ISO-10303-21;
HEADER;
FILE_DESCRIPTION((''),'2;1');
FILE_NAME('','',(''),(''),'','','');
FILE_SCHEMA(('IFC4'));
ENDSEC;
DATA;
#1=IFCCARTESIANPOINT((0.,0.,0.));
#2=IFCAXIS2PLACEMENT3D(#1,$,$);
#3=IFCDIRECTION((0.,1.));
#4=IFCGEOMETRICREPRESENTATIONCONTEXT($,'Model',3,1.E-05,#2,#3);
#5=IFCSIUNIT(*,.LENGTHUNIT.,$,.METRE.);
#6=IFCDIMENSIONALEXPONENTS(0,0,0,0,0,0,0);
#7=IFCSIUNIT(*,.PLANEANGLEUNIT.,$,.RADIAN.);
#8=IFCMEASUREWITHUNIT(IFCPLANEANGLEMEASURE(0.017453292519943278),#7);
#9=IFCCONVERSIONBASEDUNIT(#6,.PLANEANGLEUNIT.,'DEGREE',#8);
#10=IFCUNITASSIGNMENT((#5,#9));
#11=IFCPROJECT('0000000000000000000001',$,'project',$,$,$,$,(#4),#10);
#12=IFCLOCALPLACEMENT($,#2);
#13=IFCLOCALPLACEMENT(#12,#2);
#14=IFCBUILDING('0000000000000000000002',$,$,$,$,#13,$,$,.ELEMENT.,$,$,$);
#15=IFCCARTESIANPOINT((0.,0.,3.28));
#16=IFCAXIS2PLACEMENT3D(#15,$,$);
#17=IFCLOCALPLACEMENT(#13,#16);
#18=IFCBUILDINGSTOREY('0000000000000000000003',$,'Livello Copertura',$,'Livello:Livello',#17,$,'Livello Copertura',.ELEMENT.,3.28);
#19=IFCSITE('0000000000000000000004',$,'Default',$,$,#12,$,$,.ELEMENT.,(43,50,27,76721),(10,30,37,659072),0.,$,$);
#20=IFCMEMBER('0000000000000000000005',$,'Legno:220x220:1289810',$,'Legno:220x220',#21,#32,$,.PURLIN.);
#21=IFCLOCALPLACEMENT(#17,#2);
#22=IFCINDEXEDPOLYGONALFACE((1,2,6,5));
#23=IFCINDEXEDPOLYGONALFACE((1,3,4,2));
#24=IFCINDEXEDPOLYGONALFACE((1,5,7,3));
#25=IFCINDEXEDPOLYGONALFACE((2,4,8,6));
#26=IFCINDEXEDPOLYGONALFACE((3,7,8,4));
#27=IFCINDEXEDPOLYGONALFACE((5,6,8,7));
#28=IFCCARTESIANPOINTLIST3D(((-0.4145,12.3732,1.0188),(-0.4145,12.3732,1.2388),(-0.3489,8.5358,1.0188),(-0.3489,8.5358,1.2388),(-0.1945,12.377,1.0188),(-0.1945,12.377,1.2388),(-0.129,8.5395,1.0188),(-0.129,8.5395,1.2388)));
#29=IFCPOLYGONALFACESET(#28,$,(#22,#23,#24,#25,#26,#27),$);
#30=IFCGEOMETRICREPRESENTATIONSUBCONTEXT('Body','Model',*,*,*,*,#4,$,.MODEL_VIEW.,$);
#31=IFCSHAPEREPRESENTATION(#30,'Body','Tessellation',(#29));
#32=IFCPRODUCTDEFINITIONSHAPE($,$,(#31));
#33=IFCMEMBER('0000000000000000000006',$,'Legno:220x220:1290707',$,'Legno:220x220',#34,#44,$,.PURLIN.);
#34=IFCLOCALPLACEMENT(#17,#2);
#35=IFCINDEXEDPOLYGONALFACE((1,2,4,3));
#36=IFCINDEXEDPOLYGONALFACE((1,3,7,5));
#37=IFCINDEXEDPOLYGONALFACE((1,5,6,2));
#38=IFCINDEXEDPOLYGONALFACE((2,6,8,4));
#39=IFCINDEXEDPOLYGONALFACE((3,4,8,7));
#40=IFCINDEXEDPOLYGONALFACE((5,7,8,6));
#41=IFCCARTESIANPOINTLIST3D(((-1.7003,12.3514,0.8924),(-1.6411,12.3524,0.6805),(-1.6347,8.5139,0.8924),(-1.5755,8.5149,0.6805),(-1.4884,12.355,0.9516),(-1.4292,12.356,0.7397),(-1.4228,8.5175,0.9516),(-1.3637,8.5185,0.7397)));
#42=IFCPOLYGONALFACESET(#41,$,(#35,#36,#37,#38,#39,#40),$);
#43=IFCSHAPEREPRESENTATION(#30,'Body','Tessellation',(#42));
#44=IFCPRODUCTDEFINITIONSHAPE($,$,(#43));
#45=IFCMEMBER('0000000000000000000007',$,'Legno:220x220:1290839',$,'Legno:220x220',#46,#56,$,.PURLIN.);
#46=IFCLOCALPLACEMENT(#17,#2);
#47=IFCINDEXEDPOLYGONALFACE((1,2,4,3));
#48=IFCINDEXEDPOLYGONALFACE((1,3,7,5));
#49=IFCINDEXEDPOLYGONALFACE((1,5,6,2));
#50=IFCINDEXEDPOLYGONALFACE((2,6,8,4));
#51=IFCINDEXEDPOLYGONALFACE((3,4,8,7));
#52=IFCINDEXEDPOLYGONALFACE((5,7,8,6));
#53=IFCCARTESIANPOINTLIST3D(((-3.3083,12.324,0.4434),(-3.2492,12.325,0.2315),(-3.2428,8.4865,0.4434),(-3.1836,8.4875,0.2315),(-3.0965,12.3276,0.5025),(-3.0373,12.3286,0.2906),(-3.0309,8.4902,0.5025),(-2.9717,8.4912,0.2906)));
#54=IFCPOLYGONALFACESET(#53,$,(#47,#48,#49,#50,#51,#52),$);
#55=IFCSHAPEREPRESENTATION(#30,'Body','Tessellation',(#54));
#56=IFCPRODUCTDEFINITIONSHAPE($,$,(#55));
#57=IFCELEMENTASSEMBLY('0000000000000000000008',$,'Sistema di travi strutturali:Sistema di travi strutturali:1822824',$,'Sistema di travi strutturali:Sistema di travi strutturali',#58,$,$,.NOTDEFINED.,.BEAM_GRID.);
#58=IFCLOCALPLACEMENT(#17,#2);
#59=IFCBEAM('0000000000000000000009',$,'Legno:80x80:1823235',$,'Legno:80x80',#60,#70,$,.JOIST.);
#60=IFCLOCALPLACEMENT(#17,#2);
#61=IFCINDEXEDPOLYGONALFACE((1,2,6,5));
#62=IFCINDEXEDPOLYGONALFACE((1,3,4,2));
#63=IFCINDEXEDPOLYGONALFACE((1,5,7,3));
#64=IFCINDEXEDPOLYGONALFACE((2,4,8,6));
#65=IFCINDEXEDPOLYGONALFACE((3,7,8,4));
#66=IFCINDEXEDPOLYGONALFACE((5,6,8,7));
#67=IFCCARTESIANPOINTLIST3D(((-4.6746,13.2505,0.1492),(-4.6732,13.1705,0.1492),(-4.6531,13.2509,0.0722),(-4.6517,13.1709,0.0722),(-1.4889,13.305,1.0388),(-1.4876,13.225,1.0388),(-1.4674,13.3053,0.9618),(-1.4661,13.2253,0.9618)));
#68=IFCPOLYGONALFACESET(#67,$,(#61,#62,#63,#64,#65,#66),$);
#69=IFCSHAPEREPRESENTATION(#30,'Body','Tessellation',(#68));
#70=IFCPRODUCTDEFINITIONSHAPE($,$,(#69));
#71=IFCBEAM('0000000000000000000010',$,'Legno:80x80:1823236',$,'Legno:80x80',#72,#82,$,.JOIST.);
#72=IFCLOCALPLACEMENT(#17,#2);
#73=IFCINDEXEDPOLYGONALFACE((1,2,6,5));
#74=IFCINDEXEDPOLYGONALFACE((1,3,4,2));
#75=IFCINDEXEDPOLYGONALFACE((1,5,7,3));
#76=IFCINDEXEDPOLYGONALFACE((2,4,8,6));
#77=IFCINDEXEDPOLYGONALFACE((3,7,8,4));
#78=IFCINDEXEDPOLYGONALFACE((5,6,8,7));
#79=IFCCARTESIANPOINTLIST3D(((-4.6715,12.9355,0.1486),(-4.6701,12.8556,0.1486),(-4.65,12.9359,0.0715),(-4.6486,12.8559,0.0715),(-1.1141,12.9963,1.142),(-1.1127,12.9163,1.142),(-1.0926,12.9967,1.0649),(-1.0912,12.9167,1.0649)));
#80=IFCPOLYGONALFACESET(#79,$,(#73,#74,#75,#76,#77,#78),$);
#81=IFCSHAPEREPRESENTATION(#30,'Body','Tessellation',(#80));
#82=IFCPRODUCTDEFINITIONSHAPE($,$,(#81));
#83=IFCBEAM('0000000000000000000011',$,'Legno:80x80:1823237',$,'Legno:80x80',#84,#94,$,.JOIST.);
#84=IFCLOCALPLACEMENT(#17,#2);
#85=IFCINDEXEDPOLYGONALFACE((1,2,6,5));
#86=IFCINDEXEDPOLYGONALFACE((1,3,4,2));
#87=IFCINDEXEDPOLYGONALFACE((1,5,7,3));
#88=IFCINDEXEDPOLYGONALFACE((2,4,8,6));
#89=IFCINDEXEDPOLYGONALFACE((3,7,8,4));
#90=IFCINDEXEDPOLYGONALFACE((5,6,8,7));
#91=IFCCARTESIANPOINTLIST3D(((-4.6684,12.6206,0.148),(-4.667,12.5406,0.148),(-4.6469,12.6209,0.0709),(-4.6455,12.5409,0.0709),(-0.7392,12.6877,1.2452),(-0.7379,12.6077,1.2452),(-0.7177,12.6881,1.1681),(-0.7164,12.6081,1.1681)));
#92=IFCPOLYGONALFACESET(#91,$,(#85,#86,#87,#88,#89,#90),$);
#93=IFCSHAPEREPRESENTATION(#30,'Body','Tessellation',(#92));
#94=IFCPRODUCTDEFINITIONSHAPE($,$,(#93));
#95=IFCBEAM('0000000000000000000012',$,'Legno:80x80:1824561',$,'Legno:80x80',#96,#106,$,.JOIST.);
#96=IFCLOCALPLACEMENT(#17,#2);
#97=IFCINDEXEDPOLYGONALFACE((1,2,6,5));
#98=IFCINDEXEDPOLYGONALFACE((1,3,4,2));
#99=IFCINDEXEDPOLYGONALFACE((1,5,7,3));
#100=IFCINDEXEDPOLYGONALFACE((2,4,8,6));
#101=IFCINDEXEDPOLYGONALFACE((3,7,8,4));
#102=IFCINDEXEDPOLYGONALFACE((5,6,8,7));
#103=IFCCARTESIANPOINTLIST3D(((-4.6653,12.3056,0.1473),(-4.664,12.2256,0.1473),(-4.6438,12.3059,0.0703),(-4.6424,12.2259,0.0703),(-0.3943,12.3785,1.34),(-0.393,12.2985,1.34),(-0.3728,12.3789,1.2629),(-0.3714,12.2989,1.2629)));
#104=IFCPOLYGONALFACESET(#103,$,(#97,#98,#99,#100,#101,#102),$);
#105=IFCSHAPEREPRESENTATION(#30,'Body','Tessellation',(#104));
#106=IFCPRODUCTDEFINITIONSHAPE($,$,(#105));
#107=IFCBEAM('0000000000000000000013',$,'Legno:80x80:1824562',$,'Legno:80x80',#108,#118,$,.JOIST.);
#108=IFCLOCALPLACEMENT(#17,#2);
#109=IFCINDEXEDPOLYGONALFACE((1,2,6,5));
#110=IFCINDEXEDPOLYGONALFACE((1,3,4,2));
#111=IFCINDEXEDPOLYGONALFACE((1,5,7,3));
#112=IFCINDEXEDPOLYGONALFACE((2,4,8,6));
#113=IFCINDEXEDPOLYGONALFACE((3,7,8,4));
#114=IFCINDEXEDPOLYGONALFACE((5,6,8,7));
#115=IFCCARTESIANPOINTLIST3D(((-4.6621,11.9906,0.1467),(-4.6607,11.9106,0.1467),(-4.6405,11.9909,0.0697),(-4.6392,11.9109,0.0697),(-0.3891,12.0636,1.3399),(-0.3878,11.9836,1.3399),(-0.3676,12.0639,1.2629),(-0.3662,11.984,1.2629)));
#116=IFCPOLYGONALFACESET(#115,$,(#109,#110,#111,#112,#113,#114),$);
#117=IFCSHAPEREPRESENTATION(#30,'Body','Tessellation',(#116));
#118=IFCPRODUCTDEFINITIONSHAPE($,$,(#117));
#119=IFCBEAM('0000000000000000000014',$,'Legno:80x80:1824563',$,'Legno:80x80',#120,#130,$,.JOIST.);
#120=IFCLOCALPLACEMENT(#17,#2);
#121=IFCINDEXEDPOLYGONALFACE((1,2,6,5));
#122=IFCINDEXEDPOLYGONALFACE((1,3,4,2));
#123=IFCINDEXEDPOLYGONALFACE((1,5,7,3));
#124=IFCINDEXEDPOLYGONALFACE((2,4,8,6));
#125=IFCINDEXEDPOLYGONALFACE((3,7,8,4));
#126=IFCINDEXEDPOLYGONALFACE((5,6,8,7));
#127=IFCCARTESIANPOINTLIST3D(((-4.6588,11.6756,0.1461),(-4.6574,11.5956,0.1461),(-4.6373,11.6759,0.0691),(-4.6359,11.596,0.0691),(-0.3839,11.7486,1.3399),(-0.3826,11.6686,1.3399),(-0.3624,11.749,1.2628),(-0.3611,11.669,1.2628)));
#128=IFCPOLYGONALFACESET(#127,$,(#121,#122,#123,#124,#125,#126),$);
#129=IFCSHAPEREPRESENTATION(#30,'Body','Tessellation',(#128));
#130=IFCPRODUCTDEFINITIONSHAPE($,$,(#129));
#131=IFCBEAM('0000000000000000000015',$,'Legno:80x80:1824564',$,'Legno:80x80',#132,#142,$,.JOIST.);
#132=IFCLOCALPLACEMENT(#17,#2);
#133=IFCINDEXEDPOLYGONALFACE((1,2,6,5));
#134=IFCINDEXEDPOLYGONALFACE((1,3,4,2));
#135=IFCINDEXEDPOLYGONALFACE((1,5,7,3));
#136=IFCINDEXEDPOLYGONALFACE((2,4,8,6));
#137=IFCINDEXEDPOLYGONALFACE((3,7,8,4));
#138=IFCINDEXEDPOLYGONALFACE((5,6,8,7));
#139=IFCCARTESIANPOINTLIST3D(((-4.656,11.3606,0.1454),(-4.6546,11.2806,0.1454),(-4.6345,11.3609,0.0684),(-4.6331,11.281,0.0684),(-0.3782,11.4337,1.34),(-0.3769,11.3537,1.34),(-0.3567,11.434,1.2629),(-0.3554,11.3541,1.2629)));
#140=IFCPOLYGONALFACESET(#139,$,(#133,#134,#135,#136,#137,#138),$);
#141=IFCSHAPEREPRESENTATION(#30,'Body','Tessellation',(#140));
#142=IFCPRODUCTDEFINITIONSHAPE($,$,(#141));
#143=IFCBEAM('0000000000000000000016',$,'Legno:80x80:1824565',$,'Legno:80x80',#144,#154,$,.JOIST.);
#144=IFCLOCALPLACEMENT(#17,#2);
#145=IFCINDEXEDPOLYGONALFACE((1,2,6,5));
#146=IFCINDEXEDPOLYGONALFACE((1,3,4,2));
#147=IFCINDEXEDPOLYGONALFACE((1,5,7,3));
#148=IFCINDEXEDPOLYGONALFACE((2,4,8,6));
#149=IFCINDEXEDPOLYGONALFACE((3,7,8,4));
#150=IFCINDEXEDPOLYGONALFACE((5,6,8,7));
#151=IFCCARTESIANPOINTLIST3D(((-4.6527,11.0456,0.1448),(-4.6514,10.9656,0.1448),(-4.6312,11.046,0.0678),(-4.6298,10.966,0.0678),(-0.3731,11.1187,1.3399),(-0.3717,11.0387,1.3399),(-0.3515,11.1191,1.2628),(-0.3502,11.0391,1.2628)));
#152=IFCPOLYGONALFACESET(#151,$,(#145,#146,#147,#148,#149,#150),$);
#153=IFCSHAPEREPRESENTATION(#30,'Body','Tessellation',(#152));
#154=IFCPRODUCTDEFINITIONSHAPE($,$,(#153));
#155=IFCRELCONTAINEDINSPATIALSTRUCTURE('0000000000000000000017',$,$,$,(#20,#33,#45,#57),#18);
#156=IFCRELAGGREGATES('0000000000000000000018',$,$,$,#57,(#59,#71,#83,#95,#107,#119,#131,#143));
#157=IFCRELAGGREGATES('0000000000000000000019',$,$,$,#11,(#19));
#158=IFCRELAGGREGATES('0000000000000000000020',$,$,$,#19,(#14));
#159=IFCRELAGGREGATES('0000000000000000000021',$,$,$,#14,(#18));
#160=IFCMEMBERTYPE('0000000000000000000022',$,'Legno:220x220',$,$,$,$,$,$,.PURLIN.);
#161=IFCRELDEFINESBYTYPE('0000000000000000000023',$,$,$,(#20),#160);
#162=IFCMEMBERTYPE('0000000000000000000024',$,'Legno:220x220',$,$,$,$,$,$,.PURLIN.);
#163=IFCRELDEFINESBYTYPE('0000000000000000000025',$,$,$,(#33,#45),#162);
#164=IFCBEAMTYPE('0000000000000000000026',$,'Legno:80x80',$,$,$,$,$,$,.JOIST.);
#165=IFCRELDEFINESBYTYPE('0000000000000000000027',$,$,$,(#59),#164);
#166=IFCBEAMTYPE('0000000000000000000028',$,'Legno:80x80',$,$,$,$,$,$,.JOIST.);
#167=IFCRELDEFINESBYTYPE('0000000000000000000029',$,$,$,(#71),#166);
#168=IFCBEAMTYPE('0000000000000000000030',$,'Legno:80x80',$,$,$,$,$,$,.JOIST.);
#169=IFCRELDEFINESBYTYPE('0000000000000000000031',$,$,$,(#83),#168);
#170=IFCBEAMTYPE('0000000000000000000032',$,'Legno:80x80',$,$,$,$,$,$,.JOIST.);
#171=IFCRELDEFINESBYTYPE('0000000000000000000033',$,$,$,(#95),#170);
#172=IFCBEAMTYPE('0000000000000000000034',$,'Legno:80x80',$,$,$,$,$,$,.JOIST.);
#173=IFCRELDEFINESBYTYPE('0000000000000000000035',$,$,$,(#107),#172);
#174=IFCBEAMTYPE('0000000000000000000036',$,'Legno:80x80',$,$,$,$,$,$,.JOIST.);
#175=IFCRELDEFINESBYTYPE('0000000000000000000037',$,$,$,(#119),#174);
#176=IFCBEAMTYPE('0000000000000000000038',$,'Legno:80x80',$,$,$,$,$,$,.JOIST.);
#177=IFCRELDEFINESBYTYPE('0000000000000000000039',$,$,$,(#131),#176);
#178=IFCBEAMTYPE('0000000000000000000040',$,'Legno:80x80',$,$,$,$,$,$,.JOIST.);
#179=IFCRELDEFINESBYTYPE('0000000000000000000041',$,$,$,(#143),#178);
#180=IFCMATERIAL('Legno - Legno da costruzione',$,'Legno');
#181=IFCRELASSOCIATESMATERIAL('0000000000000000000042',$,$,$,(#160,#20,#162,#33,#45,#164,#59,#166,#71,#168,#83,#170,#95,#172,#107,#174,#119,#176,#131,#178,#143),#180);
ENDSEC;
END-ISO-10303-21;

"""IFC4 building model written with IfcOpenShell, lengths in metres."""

from ifc_helpers import new_model, entity, si_unit, converted_unit, direction, frame, origin, place, context, subcontext, project, spatial, indexed_curve, outline, extrude, source, transform, mapped, material, type_object, type_shapes, element, aggregate, save


model = new_model("IFC4")

# Units and contexts
model_context = context("Model", 3, precision=1e-05, world=origin(), true_north=direction((0.0, 1.0)))
body_context = subcontext(model_context, "Body", "Model", "MODEL_VIEW")
ifc_project = project(units=[si_unit("LENGTHUNIT", "METRE"), converted_unit("PLANEANGLEUNIT", "DEGREE", entity("IfcPlaneAngleMeasure", 0.017453292519943278), si_unit("PLANEANGLEUNIT", "RADIAN"), dimensions=[0, 0, 0, 0, 0, 0, 0])], contexts=[model_context])

# Site, building, storey
site_placement = place(None, origin())
site = spatial("IfcSite", under=ifc_project, at=site_placement, Name="Default", CompositionType="ELEMENT", RefLatitude=(43, 50, 27, 76721), RefLongitude=(10, 30, 37, 659072), RefElevation=0.0)
building_placement = place(site_placement, origin())
building = spatial("IfcBuilding", under=site, at=building_placement, CompositionType="ELEMENT")
storey_placement = place(building_placement, frame((0.0, 0.0, 3.28)))
storey = spatial("IfcBuildingStorey", under=building, at=storey_placement, Name="Livello Copertura", ObjectType="Livello:Livello", LongName="Livello Copertura", CompositionType="ELEMENT", Elevation=3.28)

# Members
ifc_material_1 = material(Name="Legno - Legno da costruzione", Category="Legno")
member_type_1 = type_object("IfcMemberType", Name="Legno:220x220", PredefinedType="PURLIN", material=ifc_material_1)
shared_shape_1 = source(origin(), body_context, "Body", "SweptSolid", [
    extrude(outline(indexed_curve([(-1.919, -0.11), (1.919, -0.11), (1.919, 0.11), (-1.919, 0.11), (-1.919, -0.11)], self_intersect=False)), frame((0.0, 0.0, -0.11), z_axis=(0.0, 0.0, 1.0), x_axis=(-1.0, 0.0, 0.0)), (0.0, 0.0, 1.0), 0.22),
])
type_shapes(member_type_1, [shared_shape_1])
member_placement = place(storey_placement, frame((-0.2717, 10.4564, 1.1288), z_axis=(0.0, 0.0, 1.0), x_axis=(0.017085, -0.999854, 0.0)))
element("IfcMember", 1, at=member_placement, inside=storey, type_object=member_type_1, material=ifc_material_1, Name="Legno:220x220:1289810", ObjectType="Legno:220x220", PredefinedType="PURLIN", context=body_context, shape_type="MappedRepresentation", body=[
    mapped(shared_shape_1, transform((0.0, 0.0, 0.0), scale=1.0)),
])
member_type_2 = type_object("IfcMemberType", Name="Legno:220x220", PredefinedType="PURLIN", material=ifc_material_1)
shared_shape_2 = source(origin(), body_context, "Body", "SweptSolid", [
    extrude(outline(indexed_curve([(-1.919, -0.11), (1.919, -0.11), (1.919, 0.11), (-1.919, 0.11), (-1.919, -0.11)], self_intersect=False)), frame((0.0, 0.0, -0.11), z_axis=(0.0, 0.0, 1.0), x_axis=(-1.0, 0.0, 0.0)), (0.0, 0.0, 1.0), 0.22),
])
type_shapes(member_type_2, [shared_shape_2])
for number, where, z_axis, x_axis, name in (
    (2, (-1.532, 10.435, 0.816), (-0.268881, -0.004594, 0.963163), (0.017085, -0.999854, 0.0), "Legno:220x220:1290707"),
    (3, (-3.14, 10.4076, 0.367), (-0.268881, -0.004594, 0.963163), (0.017085, -0.999854, 0.0), "Legno:220x220:1290839"),
):
    element("IfcMember", number, at=place(storey_placement, frame(where, z_axis=z_axis, x_axis=x_axis)), inside=storey, type_object=member_type_2, material=ifc_material_1, Name=name, ObjectType="Legno:220x220", PredefinedType="PURLIN", context=body_context, shape_type="MappedRepresentation", body=[
        mapped(shared_shape_2, transform((0.0, 0.0, 0.0), scale=1.0)),
    ])

# Element assembly, beams
assembly_1_placement = place(storey_placement, origin())
assembly_1 = element("IfcElementAssembly", 4, at=assembly_1_placement, inside=storey, Name="Sistema di travi strutturali:Sistema di travi strutturali:1822824", ObjectType="Sistema di travi strutturali:Sistema di travi strutturali", AssemblyPlace="NOTDEFINED", PredefinedType="BEAM_GRID")
beam_type_1 = type_object("IfcBeamType", Name="Legno:80x80", PredefinedType="JOIST", material=ifc_material_1)
shared_shape_3 = source(origin(), body_context, "Body", "SweptSolid", [
    extrude(outline(indexed_curve([(-1.654, -0.04), (1.654, -0.04), (1.654, 0.04), (-1.654, 0.04), (-1.654, -0.04)], self_intersect=False)), frame((0.0, 0.0, -0.04), z_axis=(0.0, 0.0, 1.0), x_axis=(-1.0, 0.0, 0.0)), (0.0, 0.0, 1.0), 0.08),
])
type_shapes(beam_type_1, [shared_shape_3])
beam_1_placement = place(assembly_1_placement, frame((-3.0703, 13.2379, 0.5555), z_axis=(-0.268881, -0.004594, 0.963163), x_axis=(0.963022, 0.016456, 0.26892)))
beam_1 = element("IfcBeam", 5, at=beam_1_placement, type_object=beam_type_1, material=ifc_material_1, Name="Legno:80x80:1823235", ObjectType="Legno:80x80", PredefinedType="JOIST", context=body_context, shape_type="MappedRepresentation", body=[
    mapped(shared_shape_3, transform((0.0, 0.0, 0.0), scale=1.0)),
])
beam_type_2 = type_object("IfcBeamType", Name="Legno:80x80", PredefinedType="JOIST", material=ifc_material_1)
shared_shape_4 = source(origin(), body_context, "Body", "SweptSolid", [
    extrude(outline(indexed_curve([(-1.847, -0.04), (1.847, -0.04), (1.847, 0.04), (-1.847, 0.04), (-1.847, -0.04)], self_intersect=False)), frame((0.0, 0.0, -0.04), z_axis=(0.0, 0.0, 1.0), x_axis=(-1.0, 0.0, 0.0)), (0.0, 0.0, 1.0), 0.08),
])
type_shapes(beam_type_2, [shared_shape_4])
beam_2_placement = place(assembly_1_placement, frame((-2.8814, 12.9261, 0.6068), z_axis=(-0.268881, -0.004594, 0.963163), x_axis=(0.963022, 0.016456, 0.26892)))
beam_2 = element("IfcBeam", 6, at=beam_2_placement, type_object=beam_type_2, material=ifc_material_1, Name="Legno:80x80:1823236", ObjectType="Legno:80x80", PredefinedType="JOIST", context=body_context, shape_type="MappedRepresentation", body=[
    mapped(shared_shape_4, transform((0.0, 0.0, 0.0), scale=1.0)),
])
beam_type_3 = type_object("IfcBeamType", Name="Legno:80x80", PredefinedType="JOIST", material=ifc_material_1)
shared_shape_5 = source(origin(), body_context, "Body", "SweptSolid", [
    extrude(outline(indexed_curve([(-2.04, -0.04), (2.04, -0.04), (2.04, 0.04), (-2.04, 0.04), (-2.04, -0.04)], self_intersect=False)), frame((0.0, 0.0, -0.04), z_axis=(0.0, 0.0, 1.0), x_axis=(-1.0, 0.0, 0.0)), (0.0, 0.0, 1.0), 0.08),
])
type_shapes(beam_type_3, [shared_shape_5])
beam_3_placement = place(assembly_1_placement, frame((-2.6924, 12.6143, 0.658), z_axis=(-0.268881, -0.004594, 0.963163), x_axis=(0.963022, 0.016456, 0.26892)))
beam_3 = element("IfcBeam", 7, at=beam_3_placement, type_object=beam_type_3, material=ifc_material_1, Name="Legno:80x80:1823237", ObjectType="Legno:80x80", PredefinedType="JOIST", context=body_context, shape_type="MappedRepresentation", body=[
    mapped(shared_shape_5, transform((0.0, 0.0, 0.0), scale=1.0)),
])
beam_type_4 = type_object("IfcBeamType", Name="Legno:80x80", PredefinedType="JOIST", material=ifc_material_1)
shared_shape_6 = source(origin(), body_context, "Body", "SweptSolid", [
    extrude(outline(indexed_curve([(-2.2175, -0.04), (2.2175, -0.04), (2.2175, 0.04), (-2.2175, 0.04), (-2.2175, -0.04)], self_intersect=False)), frame((0.0, 0.0, -0.04), z_axis=(0.0, 0.0, 1.0), x_axis=(-1.0, 0.0, 0.0)), (0.0, 0.0, 1.0), 0.08),
])
type_shapes(beam_type_4, [shared_shape_6])
beam_4_placement = place(assembly_1_placement, frame((-2.5184, 12.3022, 0.7051), z_axis=(-0.268881, -0.004594, 0.963163), x_axis=(0.963022, 0.016456, 0.26892)))
beam_4 = element("IfcBeam", 8, at=beam_4_placement, type_object=beam_type_4, material=ifc_material_1, Name="Legno:80x80:1824561", ObjectType="Legno:80x80", PredefinedType="JOIST", context=body_context, shape_type="MappedRepresentation", body=[
    mapped(shared_shape_6, transform((0.0, 0.0, 0.0), scale=1.0)),
])
beam_type_5 = type_object("IfcBeamType", Name="Legno:80x80", PredefinedType="JOIST", material=ifc_material_1)
shared_shape_7 = source(origin(), body_context, "Body", "SweptSolid", [
    extrude(outline(indexed_curve([(-2.2185, -0.04), (2.2185, -0.04), (2.2185, 0.04), (-2.2185, 0.04), (-2.2185, -0.04)], self_intersect=False)), frame((0.0, 0.0, -0.04), z_axis=(0.0, 0.0, 1.0), x_axis=(-1.0, 0.0, 0.0)), (0.0, 0.0, 1.0), 0.08),
])
type_shapes(beam_type_5, [shared_shape_7])
beam_5_placement = place(assembly_1_placement, frame((-2.5142, 11.9873, 0.7048), z_axis=(-0.268881, -0.004594, 0.963163), x_axis=(0.963022, 0.016456, 0.26892)))
beam_5 = element("IfcBeam", 9, at=beam_5_placement, type_object=beam_type_5, material=ifc_material_1, Name="Legno:80x80:1824562", ObjectType="Legno:80x80", PredefinedType="JOIST", context=body_context, shape_type="MappedRepresentation", body=[
    mapped(shared_shape_7, transform((0.0, 0.0, 0.0), scale=1.0)),
])
beam_type_6 = type_object("IfcBeamType", Name="Legno:80x80", PredefinedType="JOIST", material=ifc_material_1)
shared_shape_8 = source(origin(), body_context, "Body", "SweptSolid", [
    extrude(outline(indexed_curve([(-2.2195, -0.04), (2.2195, -0.04), (2.2195, 0.04), (-2.2195, 0.04), (-2.2195, -0.04)], self_intersect=False)), frame((0.0, 0.0, -0.04), z_axis=(0.0, 0.0, 1.0), x_axis=(-1.0, 0.0, 0.0)), (0.0, 0.0, 1.0), 0.08),
])
type_shapes(beam_type_6, [shared_shape_8])
beam_6_placement = place(assembly_1_placement, frame((-2.5099, 11.6723, 0.7045), z_axis=(-0.268881, -0.004594, 0.963163), x_axis=(0.963022, 0.016456, 0.26892)))
beam_6 = element("IfcBeam", 10, at=beam_6_placement, type_object=beam_type_6, material=ifc_material_1, Name="Legno:80x80:1824563", ObjectType="Legno:80x80", PredefinedType="JOIST", context=body_context, shape_type="MappedRepresentation", body=[
    mapped(shared_shape_8, transform((0.0, 0.0, 0.0), scale=1.0)),
])
beam_type_7 = type_object("IfcBeamType", Name="Legno:80x80", PredefinedType="JOIST", material=ifc_material_1)
shared_shape_9 = source(origin(), body_context, "Body", "SweptSolid", [
    extrude(outline(indexed_curve([(-2.221, -0.04), (2.221, -0.04), (2.221, 0.04), (-2.221, 0.04), (-2.221, -0.04)], self_intersect=False)), frame((0.0, 0.0, -0.04), z_axis=(0.0, 0.0, 1.0), x_axis=(-1.0, 0.0, 0.0)), (0.0, 0.0, 1.0), 0.08),
])
type_shapes(beam_type_7, [shared_shape_9])
beam_7_placement = place(assembly_1_placement, frame((-2.5057, 11.3573, 0.7042), z_axis=(-0.268881, -0.004594, 0.963163), x_axis=(0.963022, 0.016456, 0.26892)))
beam_7 = element("IfcBeam", 11, at=beam_7_placement, type_object=beam_type_7, material=ifc_material_1, Name="Legno:80x80:1824564", ObjectType="Legno:80x80", PredefinedType="JOIST", context=body_context, shape_type="MappedRepresentation", body=[
    mapped(shared_shape_9, transform((0.0, 0.0, 0.0), scale=1.0)),
])
beam_type_8 = type_object("IfcBeamType", Name="Legno:80x80", PredefinedType="JOIST", material=ifc_material_1)
shared_shape_10 = source(origin(), body_context, "Body", "SweptSolid", [
    extrude(outline(indexed_curve([(-2.222, -0.04), (2.222, -0.04), (2.222, 0.04), (-2.222, 0.04), (-2.222, -0.04)], self_intersect=False)), frame((0.0, 0.0, -0.04), z_axis=(0.0, 0.0, 1.0), x_axis=(-1.0, 0.0, 0.0)), (0.0, 0.0, 1.0), 0.08),
])
type_shapes(beam_type_8, [shared_shape_10])
beam_8_placement = place(assembly_1_placement, frame((-2.5014, 11.0423, 0.7038), z_axis=(-0.268881, -0.004594, 0.963163), x_axis=(0.963022, 0.016456, 0.26892)))
beam_8 = element("IfcBeam", 12, at=beam_8_placement, type_object=beam_type_8, material=ifc_material_1, Name="Legno:80x80:1824565", ObjectType="Legno:80x80", PredefinedType="JOIST", context=body_context, shape_type="MappedRepresentation", body=[
    mapped(shared_shape_10, transform((0.0, 0.0, 0.0), scale=1.0)),
])
aggregate(assembly_1, [beam_1, beam_2, beam_3, beam_4, beam_5, beam_6, beam_7, beam_8])

save(model, "model.ifc")
